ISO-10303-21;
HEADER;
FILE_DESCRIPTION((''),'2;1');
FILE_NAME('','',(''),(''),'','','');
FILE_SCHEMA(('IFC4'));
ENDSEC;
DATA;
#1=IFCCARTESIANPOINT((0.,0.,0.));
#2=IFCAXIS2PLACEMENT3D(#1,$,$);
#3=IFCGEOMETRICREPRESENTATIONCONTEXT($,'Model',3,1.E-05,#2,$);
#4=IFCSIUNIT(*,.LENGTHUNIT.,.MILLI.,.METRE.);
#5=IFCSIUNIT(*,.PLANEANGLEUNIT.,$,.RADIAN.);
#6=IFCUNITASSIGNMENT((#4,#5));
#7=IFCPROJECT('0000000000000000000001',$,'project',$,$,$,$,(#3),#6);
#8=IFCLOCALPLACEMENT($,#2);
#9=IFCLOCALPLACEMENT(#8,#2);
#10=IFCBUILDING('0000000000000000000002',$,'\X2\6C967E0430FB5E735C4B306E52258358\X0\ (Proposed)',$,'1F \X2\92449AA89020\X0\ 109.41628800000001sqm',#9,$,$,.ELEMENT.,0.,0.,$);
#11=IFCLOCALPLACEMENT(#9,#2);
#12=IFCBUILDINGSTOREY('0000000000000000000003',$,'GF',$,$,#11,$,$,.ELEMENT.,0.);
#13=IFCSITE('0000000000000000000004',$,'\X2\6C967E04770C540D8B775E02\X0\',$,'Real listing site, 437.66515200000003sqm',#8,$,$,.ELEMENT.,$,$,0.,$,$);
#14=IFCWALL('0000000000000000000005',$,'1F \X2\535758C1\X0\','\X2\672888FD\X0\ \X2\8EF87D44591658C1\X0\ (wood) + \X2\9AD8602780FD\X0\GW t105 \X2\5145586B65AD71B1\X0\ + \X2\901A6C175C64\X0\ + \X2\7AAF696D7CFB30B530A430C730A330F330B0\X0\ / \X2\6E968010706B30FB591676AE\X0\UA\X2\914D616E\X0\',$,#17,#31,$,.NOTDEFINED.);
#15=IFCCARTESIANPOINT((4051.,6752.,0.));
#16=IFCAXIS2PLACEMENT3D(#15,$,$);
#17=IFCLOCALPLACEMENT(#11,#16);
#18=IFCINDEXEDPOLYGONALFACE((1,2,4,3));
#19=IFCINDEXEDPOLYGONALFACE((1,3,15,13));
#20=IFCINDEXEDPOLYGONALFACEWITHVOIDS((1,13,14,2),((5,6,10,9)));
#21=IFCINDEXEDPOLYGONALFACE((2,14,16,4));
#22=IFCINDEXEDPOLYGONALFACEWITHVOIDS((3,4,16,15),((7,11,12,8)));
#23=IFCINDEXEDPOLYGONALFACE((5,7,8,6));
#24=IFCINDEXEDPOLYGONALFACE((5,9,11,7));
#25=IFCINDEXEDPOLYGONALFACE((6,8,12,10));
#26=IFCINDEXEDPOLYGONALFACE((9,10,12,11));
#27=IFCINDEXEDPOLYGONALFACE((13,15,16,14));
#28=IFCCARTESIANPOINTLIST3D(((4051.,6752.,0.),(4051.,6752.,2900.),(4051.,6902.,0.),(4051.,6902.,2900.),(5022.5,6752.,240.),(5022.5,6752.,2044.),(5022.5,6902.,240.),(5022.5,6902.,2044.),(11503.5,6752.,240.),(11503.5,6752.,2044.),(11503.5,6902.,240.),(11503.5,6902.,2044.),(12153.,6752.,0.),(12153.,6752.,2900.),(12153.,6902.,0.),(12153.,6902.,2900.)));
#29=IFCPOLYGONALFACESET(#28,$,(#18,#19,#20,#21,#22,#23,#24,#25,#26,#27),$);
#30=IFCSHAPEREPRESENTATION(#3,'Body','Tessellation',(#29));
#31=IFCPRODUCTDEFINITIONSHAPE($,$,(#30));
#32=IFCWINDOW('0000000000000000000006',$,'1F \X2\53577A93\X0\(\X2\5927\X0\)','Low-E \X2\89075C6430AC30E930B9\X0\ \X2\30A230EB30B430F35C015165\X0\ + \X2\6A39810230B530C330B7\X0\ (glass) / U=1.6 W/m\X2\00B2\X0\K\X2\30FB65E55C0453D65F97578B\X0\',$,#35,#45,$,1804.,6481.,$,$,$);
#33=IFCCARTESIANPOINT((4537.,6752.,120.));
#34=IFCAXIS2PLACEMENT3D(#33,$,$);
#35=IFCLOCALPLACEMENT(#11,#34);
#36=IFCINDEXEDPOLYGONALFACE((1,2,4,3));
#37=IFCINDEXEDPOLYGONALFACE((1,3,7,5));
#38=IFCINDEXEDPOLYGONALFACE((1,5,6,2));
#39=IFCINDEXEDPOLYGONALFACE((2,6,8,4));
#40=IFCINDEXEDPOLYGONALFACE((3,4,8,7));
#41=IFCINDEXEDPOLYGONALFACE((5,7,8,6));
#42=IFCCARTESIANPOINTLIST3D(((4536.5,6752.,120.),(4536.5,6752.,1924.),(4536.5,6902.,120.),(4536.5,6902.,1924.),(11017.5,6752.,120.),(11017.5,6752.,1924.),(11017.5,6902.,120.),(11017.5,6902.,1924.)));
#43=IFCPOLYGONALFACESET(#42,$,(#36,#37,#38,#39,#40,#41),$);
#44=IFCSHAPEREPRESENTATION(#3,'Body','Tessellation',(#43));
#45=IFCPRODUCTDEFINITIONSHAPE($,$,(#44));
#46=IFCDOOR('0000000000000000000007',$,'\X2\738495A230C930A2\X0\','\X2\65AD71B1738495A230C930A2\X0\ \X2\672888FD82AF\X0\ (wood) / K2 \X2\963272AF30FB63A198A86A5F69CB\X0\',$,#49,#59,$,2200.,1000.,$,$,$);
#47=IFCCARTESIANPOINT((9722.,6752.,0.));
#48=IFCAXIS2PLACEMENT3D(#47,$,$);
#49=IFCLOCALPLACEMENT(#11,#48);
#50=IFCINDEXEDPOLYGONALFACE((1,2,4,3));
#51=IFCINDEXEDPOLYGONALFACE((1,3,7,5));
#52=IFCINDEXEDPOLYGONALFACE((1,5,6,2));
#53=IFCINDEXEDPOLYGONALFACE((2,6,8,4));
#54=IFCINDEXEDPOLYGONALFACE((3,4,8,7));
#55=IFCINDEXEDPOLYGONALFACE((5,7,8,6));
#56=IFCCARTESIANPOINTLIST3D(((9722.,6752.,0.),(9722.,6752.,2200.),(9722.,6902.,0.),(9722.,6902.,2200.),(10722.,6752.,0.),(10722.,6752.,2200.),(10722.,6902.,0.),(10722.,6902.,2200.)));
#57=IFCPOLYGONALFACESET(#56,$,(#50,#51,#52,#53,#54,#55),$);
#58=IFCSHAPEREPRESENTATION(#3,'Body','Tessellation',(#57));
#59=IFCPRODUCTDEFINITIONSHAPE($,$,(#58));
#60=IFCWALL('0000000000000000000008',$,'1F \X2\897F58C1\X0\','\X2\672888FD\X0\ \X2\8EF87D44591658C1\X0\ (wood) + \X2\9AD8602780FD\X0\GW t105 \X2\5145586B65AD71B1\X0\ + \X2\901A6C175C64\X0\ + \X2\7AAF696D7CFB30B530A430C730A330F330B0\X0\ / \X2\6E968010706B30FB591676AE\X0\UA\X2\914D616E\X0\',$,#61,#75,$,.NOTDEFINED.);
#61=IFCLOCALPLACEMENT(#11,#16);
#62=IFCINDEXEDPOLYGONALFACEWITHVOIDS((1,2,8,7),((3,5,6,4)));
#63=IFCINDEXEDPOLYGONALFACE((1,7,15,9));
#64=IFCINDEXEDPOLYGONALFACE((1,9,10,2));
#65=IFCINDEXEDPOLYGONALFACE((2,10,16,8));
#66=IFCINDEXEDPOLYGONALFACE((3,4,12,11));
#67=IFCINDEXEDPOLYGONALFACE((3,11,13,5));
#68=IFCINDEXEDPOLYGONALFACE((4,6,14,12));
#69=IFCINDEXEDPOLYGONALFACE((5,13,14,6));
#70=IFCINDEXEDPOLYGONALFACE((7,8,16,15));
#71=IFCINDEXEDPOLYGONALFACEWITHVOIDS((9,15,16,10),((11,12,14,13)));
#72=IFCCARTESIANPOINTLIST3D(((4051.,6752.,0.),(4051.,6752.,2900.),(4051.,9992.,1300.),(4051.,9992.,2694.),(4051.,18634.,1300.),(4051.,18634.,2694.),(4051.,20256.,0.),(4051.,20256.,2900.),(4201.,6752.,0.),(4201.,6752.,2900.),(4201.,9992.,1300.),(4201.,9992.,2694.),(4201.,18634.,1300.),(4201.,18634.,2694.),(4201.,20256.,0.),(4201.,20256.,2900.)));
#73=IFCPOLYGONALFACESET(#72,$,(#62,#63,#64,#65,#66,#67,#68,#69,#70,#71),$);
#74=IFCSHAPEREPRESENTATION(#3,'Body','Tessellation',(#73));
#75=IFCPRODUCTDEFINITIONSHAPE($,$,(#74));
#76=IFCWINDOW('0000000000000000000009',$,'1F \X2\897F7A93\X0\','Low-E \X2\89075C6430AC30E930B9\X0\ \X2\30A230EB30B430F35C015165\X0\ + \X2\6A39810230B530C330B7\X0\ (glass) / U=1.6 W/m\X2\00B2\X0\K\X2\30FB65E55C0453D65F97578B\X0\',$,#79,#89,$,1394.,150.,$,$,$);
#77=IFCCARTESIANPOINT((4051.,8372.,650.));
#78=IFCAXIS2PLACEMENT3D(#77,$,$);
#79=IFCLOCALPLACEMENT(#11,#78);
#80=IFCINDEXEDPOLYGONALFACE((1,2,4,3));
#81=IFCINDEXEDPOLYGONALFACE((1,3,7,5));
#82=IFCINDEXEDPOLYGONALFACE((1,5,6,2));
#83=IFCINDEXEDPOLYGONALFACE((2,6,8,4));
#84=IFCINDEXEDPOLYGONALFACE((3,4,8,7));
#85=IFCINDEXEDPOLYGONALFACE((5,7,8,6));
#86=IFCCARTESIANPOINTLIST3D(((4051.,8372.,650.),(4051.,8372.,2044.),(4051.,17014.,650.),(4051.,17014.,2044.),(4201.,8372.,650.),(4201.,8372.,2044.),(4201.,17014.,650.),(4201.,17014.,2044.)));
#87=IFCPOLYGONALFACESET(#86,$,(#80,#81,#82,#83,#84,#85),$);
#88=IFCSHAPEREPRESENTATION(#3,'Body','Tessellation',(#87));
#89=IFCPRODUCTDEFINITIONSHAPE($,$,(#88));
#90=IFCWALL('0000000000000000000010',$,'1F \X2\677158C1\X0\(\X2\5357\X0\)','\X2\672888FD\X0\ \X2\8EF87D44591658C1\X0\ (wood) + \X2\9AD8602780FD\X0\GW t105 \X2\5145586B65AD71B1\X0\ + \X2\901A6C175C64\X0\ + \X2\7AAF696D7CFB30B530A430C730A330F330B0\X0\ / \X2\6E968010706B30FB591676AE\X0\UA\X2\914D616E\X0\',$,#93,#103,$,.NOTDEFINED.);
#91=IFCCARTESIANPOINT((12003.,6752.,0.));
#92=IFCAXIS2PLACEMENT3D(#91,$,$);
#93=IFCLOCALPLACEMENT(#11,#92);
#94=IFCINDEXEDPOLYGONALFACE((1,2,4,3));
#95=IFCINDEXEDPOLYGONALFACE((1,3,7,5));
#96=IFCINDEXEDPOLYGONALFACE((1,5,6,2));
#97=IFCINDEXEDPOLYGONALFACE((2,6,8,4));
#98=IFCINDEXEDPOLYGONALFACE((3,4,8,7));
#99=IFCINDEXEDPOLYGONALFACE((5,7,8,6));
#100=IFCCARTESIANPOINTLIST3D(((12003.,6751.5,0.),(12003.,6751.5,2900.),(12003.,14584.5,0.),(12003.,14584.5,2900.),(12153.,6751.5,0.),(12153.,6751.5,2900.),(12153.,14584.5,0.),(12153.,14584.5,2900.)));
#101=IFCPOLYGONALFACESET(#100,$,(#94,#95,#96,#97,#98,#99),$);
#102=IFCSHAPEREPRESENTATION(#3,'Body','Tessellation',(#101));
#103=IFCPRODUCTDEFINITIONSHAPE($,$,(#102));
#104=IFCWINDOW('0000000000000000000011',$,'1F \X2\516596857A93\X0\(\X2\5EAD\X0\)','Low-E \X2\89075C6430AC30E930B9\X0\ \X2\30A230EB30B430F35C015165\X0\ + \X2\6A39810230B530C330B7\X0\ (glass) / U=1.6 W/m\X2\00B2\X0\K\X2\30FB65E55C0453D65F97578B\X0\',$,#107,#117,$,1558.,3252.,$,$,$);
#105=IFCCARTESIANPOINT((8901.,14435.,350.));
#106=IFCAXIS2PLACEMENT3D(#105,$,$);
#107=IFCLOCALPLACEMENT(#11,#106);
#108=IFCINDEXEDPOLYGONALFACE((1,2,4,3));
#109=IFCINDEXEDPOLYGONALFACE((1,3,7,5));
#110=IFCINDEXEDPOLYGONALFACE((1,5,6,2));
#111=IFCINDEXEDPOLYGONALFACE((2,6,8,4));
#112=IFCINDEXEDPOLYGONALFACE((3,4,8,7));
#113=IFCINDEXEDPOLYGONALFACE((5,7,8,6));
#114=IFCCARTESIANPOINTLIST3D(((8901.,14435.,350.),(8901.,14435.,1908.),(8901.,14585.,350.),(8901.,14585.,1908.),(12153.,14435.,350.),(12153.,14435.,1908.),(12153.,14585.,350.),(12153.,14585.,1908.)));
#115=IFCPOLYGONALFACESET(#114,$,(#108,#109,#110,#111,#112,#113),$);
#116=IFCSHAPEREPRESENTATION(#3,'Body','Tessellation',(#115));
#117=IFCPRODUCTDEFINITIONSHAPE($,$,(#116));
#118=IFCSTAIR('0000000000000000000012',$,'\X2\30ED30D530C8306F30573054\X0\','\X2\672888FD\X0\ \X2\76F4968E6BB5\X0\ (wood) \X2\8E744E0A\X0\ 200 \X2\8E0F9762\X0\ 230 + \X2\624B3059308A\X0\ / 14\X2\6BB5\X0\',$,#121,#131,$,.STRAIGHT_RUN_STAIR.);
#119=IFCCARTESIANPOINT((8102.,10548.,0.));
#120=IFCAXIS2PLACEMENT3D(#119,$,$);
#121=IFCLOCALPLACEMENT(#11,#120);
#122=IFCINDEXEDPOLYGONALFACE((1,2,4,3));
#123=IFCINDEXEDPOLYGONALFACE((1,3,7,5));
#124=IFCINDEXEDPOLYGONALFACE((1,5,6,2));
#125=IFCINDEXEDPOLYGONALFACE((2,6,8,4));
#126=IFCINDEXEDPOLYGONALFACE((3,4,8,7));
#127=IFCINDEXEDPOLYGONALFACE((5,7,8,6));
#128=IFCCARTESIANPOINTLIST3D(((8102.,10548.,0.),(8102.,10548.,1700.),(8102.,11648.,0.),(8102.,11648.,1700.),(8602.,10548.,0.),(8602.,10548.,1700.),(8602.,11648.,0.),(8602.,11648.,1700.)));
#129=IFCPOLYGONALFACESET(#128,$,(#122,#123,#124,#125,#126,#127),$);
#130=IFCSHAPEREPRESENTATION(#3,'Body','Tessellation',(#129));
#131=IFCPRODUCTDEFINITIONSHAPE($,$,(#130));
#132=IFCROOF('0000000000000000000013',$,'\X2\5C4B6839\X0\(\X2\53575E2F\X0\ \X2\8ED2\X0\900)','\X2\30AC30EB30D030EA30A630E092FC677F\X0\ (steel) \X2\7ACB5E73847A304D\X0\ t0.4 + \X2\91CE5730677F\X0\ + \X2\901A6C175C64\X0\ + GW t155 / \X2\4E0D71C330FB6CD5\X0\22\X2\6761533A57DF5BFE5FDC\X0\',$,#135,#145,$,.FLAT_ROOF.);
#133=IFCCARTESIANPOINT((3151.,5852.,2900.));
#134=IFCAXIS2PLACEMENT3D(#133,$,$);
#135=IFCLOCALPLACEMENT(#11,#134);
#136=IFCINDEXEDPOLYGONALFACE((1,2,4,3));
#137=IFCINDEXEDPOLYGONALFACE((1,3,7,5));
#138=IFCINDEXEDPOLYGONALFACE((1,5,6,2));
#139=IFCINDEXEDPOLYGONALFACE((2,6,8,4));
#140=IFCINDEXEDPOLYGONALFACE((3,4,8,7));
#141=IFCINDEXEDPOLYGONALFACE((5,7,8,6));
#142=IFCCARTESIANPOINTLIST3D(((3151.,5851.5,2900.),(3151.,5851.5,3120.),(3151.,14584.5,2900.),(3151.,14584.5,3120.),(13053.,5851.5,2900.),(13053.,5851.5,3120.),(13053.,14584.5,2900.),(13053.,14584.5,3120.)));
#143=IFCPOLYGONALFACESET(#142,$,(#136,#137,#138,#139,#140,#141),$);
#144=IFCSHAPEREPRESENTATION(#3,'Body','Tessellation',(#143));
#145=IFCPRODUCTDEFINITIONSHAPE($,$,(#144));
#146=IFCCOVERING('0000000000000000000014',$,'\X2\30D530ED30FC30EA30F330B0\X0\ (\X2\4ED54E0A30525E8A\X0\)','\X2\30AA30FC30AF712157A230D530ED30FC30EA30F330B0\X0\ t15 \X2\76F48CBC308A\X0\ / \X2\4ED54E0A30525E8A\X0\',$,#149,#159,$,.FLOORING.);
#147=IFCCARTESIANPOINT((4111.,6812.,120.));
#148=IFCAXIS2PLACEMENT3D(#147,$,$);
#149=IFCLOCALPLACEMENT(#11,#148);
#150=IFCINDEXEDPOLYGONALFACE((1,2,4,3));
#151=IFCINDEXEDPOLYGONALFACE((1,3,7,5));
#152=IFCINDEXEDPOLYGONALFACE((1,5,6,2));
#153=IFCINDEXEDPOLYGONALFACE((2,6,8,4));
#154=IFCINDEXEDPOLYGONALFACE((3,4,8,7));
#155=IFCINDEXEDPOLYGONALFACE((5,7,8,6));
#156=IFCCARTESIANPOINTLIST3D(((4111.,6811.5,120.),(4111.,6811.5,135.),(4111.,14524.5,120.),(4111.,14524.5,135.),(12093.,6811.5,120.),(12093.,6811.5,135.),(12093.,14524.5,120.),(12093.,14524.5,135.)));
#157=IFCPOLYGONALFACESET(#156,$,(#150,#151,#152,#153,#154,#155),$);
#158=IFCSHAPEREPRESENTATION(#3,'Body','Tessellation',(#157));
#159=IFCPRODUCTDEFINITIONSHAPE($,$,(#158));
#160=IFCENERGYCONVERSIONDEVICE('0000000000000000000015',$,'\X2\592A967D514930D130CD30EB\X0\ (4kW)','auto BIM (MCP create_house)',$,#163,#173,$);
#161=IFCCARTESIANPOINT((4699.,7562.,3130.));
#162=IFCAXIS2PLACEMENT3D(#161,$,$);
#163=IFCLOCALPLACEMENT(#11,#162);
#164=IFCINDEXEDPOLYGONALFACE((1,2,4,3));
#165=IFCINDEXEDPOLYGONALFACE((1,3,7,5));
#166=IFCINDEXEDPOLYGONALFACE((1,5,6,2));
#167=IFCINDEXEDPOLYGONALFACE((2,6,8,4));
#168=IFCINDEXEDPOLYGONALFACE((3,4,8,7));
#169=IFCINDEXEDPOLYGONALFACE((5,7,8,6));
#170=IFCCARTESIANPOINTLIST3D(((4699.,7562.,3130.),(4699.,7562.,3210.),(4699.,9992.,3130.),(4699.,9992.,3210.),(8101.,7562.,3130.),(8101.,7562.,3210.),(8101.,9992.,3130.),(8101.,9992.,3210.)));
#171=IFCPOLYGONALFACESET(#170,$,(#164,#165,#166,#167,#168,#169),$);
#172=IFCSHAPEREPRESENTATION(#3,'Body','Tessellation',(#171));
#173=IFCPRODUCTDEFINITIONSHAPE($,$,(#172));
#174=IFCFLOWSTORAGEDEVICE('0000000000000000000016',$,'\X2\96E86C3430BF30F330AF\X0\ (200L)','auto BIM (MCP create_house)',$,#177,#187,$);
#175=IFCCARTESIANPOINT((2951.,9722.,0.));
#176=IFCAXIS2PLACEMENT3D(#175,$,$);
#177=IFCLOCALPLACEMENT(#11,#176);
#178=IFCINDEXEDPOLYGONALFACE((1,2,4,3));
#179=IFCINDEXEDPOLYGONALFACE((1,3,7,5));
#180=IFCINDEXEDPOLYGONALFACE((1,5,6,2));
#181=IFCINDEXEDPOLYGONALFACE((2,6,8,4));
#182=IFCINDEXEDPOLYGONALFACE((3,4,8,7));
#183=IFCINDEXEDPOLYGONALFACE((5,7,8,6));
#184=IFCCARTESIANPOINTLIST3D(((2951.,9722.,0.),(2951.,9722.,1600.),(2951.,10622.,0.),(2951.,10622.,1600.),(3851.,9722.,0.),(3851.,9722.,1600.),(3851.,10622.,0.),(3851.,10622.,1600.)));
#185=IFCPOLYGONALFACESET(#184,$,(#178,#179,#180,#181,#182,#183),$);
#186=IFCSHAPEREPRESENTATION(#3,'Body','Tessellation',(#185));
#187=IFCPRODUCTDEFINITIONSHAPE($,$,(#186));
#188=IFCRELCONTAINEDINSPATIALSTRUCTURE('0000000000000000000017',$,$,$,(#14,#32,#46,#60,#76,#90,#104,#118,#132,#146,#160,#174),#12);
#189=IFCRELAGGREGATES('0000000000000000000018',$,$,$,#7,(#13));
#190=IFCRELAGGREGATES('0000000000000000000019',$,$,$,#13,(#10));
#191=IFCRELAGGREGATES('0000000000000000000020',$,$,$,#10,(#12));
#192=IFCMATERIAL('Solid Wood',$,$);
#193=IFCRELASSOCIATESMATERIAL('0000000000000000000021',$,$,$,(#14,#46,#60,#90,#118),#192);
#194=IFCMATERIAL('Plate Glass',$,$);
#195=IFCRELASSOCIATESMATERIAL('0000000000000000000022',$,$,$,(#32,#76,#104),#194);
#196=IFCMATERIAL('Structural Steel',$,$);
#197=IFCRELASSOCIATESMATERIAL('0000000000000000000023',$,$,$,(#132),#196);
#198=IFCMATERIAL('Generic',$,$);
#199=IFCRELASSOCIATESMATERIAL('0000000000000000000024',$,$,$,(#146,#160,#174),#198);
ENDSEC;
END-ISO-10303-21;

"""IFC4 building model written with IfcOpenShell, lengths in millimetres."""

from ifc_helpers import new_model, si_unit, frame, frame_2d, origin, place, context, project, spatial, rectangle, extrude, material, element, fill, save


model = new_model("IFC4")

# Units and contexts
model_context = context("Model", 3, precision=1e-05, world=origin())
ifc_project = project(units=[si_unit("LENGTHUNIT", "METRE", prefix="MILLI"), si_unit("PLANEANGLEUNIT", "RADIAN")], contexts=[model_context])

# Site, building, storey
site_placement = place(None, origin())
site = spatial("IfcSite", under=ifc_project, at=site_placement, Name="沖縄県名護市", ObjectType="Real listing site, 437.66515200000003sqm", CompositionType="ELEMENT", RefElevation=0.0)
building_placement = place(site_placement, origin())
building = spatial("IfcBuilding", under=site, at=building_placement, Name="沖縄・平屋の別荘 (Proposed)", ObjectType="1F 鉄骨造 109.41628800000001sqm", CompositionType="ELEMENT", ElevationOfRefHeight=0.0, ElevationOfTerrain=0.0)
storey_placement = place(building_placement, origin())
storey = spatial("IfcBuildingStorey", under=building, at=storey_placement, Name="GF", CompositionType="ELEMENT", Elevation=0.0)

# Shared definitions
ifc_material_1 = material(Name="Solid Wood")

# Wall, openings, window, door
wall_1_placement = place(storey_placement, frame((4051.0, 6752.0, 0.0)))
wall_1 = element("IfcWall", 1, at=wall_1_placement, inside=storey, material=ifc_material_1, Name="1F 南壁", Description="木製 軸組外壁 (wood) + 高性能GW t105 充填断熱 + 通気層 + 窯業系サイディング / 準耐火・外皮UA配慮", PredefinedType="NOTDEFINED", context=model_context, shape_type="SweptSolid", body=[
    extrude(rectangle(XDim=8102.0, YDim=150.0, at=frame_2d((4051.0, 75.0))), frame((4051.0, 6752.0, 0.0)), (0.0, 0.0, 1.0), 2900.0),
])
opening_1_placement = place(storey_placement, frame((4537.0, 6752.0, 120.0)))
opening_1 = element("IfcOpeningElement", 2, at=opening_1_placement, cuts=wall_1, PredefinedType="NOTDEFINED", context=model_context, shape_type="SweptSolid", body=[
    extrude(rectangle(XDim=6481.0, YDim=150.0, at=frame_2d((3240.0, 75.0))), frame((4537.0, 6752.0, 120.0)), (0.0, 0.0, 1.0), 1804.0),
])
opening_2_placement = place(storey_placement, frame((9722.0, 6752.0, 0.0)))
opening_2 = element("IfcOpeningElement", 3, at=opening_2_placement, cuts=wall_1, PredefinedType="NOTDEFINED", context=model_context, shape_type="SweptSolid", body=[
    extrude(rectangle(XDim=1000.0, YDim=150.0, at=frame_2d((500.0, 75.0))), frame((9722.0, 6752.0, 0.0)), (0.0, 0.0, 1.0), 2200.0),
])
ifc_material_2 = material(Name="Plate Glass")
window_1_placement = place(storey_placement, frame((4537.0, 6752.0, 120.0)))
window_1 = element("IfcWindow", 4, at=window_1_placement, inside=storey, material=ifc_material_2, Name="1F 南窓(大)", Description="Low-E 複層ガラス アルゴン封入 + 樹脂サッシ (glass) / U=1.6 W/m²K・日射取得型", OverallHeight=1804.0, OverallWidth=6481.0, context=model_context, shape_type="SweptSolid", body=[
    extrude(rectangle(XDim=6481.0, YDim=150.0, at=frame_2d((3240.0, 75.0))), frame((4537.0, 6752.0, 120.0)), (0.0, 0.0, 1.0), 1804.0),
])
fill(opening_1, window_1)
door_1_placement = place(storey_placement, frame((9722.0, 6752.0, 0.0)))
door_1 = element("IfcDoor", 5, at=door_1_placement, inside=storey, material=ifc_material_1, Name="玄関ドア", Description="断熱玄関ドア 木製芯 (wood) / K2 防犯・採風機構", OverallHeight=2200.0, OverallWidth=1000.0, context=model_context, shape_type="SweptSolid", body=[
    extrude(rectangle(XDim=1000.0, YDim=150.0, at=frame_2d((500.0, 75.0))), frame((9722.0, 6752.0, 0.0)), (0.0, 0.0, 1.0), 2200.0),
])
fill(opening_2, door_1)

# Walls, openings, windows
wall_2_placement = place(storey_placement, frame((4051.0, 6752.0, 0.0)))
wall_2 = element("IfcWall", 6, at=wall_2_placement, inside=storey, material=ifc_material_1, Name="1F 西壁", Description="木製 軸組外壁 (wood) + 高性能GW t105 充填断熱 + 通気層 + 窯業系サイディング / 準耐火・外皮UA配慮", PredefinedType="NOTDEFINED", context=model_context, shape_type="SweptSolid", body=[
    extrude(rectangle(XDim=150.0, YDim=13504.0, at=frame_2d((75.0, 6752.0))), frame((4051.0, 6752.0, 0.0)), (0.0, 0.0, 1.0), 2900.0),
])
opening_3_placement = place(storey_placement, frame((4051.0, 8372.0, 650.0)))
opening_3 = element("IfcOpeningElement", 7, at=opening_3_placement, cuts=wall_2, PredefinedType="NOTDEFINED", context=model_context, shape_type="SweptSolid", body=[
    extrude(rectangle(XDim=150.0, YDim=8642.0, at=frame_2d((75.0, 4321.0))), frame((4051.0, 8372.0, 650.0)), (0.0, 0.0, 1.0), 1394.0),
])
window_2_placement = place(storey_placement, frame((4051.0, 8372.0, 650.0)))
window_2 = element("IfcWindow", 8, at=window_2_placement, inside=storey, material=ifc_material_2, Name="1F 西窓", Description="Low-E 複層ガラス アルゴン封入 + 樹脂サッシ (glass) / U=1.6 W/m²K・日射取得型", OverallHeight=1394.0, OverallWidth=150.0, context=model_context, shape_type="SweptSolid", body=[
    extrude(rectangle(XDim=150.0, YDim=8642.0, at=frame_2d((75.0, 4321.0))), frame((4051.0, 8372.0, 650.0)), (0.0, 0.0, 1.0), 1394.0),
])
fill(opening_3, window_2)
wall_3_placement = place(storey_placement, frame((12003.0, 6752.0, 0.0)))
wall_3 = element("IfcWall", 9, at=wall_3_placement, inside=storey, material=ifc_material_1, Name="1F 東壁(南)", Description="木製 軸組外壁 (wood) + 高性能GW t105 充填断熱 + 通気層 + 窯業系サイディング / 準耐火・外皮UA配慮", PredefinedType="NOTDEFINED", context=model_context, shape_type="SweptSolid", body=[
    extrude(rectangle(XDim=150.0, YDim=7833.0, at=frame_2d((75.0, 3916.0))), frame((12003.0, 6752.0, 0.0)), (0.0, 0.0, 1.0), 2900.0),
])
opening_4_placement = place(storey_placement, frame((8901.0, 14435.0, 350.0)))
opening_4 = element("IfcOpeningElement", 10, at=opening_4_placement, cuts=wall_3, PredefinedType="NOTDEFINED", context=model_context, shape_type="SweptSolid", body=[
    extrude(rectangle(XDim=3252.0, YDim=150.0, at=frame_2d((1626.0, 75.0))), frame((8901.0, 14435.0, 350.0)), (0.0, 0.0, 1.0), 1558.0),
])
window_3_placement = place(storey_placement, frame((8901.0, 14435.0, 350.0)))
window_3 = element("IfcWindow", 11, at=window_3_placement, inside=storey, material=ifc_material_2, Name="1F 入隅窓(庭)", Description="Low-E 複層ガラス アルゴン封入 + 樹脂サッシ (glass) / U=1.6 W/m²K・日射取得型", OverallHeight=1558.0, OverallWidth=3252.0, context=model_context, shape_type="SweptSolid", body=[
    extrude(rectangle(XDim=3252.0, YDim=150.0, at=frame_2d((1626.0, 75.0))), frame((8901.0, 14435.0, 350.0)), (0.0, 0.0, 1.0), 1558.0),
])
fill(opening_4, window_3)

# Stair
stair_placement = place(storey_placement, frame((8102.0, 10548.0, 0.0)))
element("IfcStair", 12, at=stair_placement, inside=storey, material=ifc_material_1, Name="ロフトはしご", Description="木製 直階段 (wood) 蹴上 200 踏面 230 + 手すり / 14段", PredefinedType="STRAIGHT_RUN_STAIR", context=model_context, shape_type="SweptSolid", body=[
    extrude(rectangle(XDim=500.0, YDim=1100.0, at=frame_2d((250.0, 550.0))), frame((8102.0, 10548.0, 0.0)), (0.0, 0.0, 1.0), 1700.0),
])

# Roof
ifc_material_3 = material(Name="Structural Steel")
roof_placement = place(storey_placement, frame((3151.0, 5852.0, 2900.0)))
element("IfcRoof", 13, at=roof_placement, inside=storey, material=ifc_material_3, Name="屋根(南帯 軒900)", Description="ガルバリウム鋼板 (steel) 立平葺き t0.4 + 野地板 + 通気層 + GW t155 / 不燃・法22条区域対応", PredefinedType="FLAT_ROOF", context=model_context, shape_type="SweptSolid", body=[
    extrude(rectangle(XDim=9902.0, YDim=8733.0, at=frame_2d((4951.0, 4366.0))), frame((3151.0, 5852.0, 2900.0)), (0.0, 0.0, 1.0), 220.0),
])

# Covering
ifc_material_4 = material(Name="Generic")
covering_placement = place(storey_placement, frame((4111.0, 6812.0, 120.0)))
element("IfcCovering", 14, at=covering_placement, inside=storey, material=ifc_material_4, Name="フローリング (仕上げ床)", Description="オーク無垢フローリング t15 直貼り / 仕上げ床", PredefinedType="FLOORING", context=model_context, shape_type="SweptSolid", body=[
    extrude(rectangle(XDim=7982.0, YDim=7713.0, at=frame_2d((3991.0, 3856.0))), frame((4111.0, 6812.0, 120.0)), (0.0, 0.0, 1.0), 15.0),
])

# Energy conversion device
energy_conversion_device_placement = place(storey_placement, frame((4699.0, 7562.0, 3130.0)))
element("IfcEnergyConversionDevice", 15, at=energy_conversion_device_placement, inside=storey, material=ifc_material_4, Name="太陽光パネル (4kW)", Description="auto BIM (MCP create_house)", context=model_context, shape_type="SweptSolid", body=[
    extrude(rectangle(XDim=3402.0, YDim=2430.0, at=frame_2d((1701.0, 1215.0))), frame((4699.0, 7562.0, 3130.0)), (0.0, 0.0, 1.0), 80.0),
])

# Flow storage device
flow_storage_device_placement = place(storey_placement, frame((2951.0, 9722.0, 0.0)))
element("IfcFlowStorageDevice", 16, at=flow_storage_device_placement, inside=storey, material=ifc_material_4, Name="雨水タンク (200L)", Description="auto BIM (MCP create_house)", context=model_context, shape_type="SweptSolid", body=[
    extrude(rectangle(XDim=900.0, YDim=900.0, at=frame_2d((450.0, 450.0))), frame((2951.0, 9722.0, 0.0)), (0.0, 0.0, 1.0), 1600.0),
])

save(model, "model.ifc")
